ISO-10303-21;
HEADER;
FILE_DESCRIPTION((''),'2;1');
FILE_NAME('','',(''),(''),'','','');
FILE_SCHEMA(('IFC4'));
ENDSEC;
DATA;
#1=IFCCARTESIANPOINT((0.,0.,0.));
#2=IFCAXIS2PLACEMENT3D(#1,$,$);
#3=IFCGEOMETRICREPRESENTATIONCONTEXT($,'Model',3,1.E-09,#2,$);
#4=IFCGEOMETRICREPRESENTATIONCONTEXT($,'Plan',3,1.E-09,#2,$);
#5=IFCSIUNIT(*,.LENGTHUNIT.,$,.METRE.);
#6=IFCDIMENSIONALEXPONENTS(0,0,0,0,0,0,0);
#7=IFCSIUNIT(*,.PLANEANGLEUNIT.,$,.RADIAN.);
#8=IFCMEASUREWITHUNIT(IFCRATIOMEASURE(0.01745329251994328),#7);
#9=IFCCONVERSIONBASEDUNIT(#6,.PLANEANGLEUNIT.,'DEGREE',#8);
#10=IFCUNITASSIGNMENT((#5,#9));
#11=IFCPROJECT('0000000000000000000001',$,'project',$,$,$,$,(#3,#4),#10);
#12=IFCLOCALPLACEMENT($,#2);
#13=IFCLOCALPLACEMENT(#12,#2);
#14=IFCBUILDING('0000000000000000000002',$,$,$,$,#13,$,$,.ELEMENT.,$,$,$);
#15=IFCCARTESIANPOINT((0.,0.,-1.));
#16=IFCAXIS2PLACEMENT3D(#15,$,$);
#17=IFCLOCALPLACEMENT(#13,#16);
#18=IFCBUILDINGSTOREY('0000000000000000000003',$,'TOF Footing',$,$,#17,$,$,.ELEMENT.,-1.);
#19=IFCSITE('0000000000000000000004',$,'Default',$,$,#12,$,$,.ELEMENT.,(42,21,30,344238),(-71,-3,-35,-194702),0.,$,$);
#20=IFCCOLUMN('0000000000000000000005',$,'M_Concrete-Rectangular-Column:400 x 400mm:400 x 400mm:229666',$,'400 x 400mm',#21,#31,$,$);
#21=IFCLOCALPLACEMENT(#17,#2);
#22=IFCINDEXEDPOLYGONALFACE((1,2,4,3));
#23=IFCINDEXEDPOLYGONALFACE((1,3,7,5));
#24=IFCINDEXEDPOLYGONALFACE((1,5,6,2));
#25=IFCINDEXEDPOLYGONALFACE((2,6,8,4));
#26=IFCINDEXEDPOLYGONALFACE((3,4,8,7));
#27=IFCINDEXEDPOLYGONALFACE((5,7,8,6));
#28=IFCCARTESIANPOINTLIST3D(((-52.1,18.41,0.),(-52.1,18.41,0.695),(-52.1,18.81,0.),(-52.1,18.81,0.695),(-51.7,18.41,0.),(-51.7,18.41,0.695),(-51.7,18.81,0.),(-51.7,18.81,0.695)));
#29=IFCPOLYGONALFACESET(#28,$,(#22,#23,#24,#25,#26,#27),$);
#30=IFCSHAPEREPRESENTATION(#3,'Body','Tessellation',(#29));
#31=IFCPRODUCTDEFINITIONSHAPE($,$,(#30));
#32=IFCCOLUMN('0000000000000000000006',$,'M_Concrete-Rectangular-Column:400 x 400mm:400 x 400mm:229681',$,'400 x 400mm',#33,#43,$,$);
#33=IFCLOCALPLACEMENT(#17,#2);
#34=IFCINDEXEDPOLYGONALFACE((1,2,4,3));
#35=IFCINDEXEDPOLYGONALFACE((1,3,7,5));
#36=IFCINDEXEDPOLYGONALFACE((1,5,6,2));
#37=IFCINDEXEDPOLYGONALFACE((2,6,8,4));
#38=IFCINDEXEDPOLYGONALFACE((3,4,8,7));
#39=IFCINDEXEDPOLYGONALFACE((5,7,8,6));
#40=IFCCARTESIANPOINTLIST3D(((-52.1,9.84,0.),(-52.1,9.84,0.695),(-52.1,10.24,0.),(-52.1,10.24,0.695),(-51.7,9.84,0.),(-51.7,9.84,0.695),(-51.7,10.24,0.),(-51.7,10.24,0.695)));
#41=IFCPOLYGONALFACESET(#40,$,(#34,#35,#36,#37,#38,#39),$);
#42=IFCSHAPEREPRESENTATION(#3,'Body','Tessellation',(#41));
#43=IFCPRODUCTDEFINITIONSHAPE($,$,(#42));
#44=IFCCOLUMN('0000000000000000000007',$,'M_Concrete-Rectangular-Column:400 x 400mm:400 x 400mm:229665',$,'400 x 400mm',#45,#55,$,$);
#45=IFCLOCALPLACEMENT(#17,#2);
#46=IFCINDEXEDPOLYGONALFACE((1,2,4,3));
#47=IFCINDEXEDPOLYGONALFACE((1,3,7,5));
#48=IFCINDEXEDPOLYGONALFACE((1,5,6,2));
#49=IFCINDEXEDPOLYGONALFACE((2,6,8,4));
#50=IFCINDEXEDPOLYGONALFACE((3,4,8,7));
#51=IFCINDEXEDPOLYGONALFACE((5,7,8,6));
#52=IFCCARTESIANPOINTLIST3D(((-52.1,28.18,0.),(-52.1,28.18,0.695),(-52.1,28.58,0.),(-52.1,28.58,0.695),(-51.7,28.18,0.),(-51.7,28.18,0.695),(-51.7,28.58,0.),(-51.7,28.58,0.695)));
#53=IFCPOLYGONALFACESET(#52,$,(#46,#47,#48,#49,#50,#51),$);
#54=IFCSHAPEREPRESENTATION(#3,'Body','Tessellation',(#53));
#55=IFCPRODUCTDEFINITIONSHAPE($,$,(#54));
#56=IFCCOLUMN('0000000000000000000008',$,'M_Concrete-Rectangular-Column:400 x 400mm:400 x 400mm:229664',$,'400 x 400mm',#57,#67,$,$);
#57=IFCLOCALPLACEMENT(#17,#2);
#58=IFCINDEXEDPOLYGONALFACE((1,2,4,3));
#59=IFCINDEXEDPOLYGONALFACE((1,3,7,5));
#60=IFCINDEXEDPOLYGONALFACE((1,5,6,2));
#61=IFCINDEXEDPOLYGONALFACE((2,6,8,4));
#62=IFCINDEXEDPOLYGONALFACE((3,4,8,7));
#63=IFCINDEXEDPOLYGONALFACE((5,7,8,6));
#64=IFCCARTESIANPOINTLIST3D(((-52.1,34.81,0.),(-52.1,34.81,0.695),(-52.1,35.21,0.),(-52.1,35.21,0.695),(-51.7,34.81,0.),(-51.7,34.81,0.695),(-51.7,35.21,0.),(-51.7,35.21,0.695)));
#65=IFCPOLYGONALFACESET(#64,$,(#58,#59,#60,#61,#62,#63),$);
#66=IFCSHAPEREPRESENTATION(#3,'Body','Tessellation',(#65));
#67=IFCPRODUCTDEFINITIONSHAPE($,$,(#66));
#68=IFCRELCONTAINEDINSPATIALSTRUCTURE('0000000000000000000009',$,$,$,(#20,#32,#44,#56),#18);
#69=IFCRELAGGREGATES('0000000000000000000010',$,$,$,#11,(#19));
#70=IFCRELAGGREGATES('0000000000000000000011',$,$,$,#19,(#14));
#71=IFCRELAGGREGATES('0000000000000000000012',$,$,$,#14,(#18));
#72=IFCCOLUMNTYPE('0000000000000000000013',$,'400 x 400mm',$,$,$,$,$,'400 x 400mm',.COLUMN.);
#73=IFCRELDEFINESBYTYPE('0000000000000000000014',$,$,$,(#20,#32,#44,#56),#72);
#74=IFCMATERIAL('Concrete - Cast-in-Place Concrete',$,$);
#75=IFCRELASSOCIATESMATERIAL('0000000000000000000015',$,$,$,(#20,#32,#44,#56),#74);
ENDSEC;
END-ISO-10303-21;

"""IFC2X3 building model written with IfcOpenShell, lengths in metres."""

from ifc_helpers import new_model, entity, si_unit, converted_unit, frame, frame_2d, origin, place, context, project, spatial, rectangle, extrude, source, transform, mapped, material, type_object, type_shapes, element, save


model = new_model("IFC2X3")

# Units and contexts
model_context = context("Model", 3, precision=1e-09, world=origin())
plan_context = context("Plan", 3, precision=1e-09, world=origin())
ifc_project = project(units=[si_unit("LENGTHUNIT", "METRE"), converted_unit("PLANEANGLEUNIT", "DEGREE", entity("IfcRatioMeasure", 0.01745329251994328), si_unit("PLANEANGLEUNIT", "RADIAN"), dimensions=[0, 0, 0, 0, 0, 0, 0])], contexts=[model_context, plan_context])

# Site, building, storey
site_placement = place(None, origin())
site = spatial("IfcSite", under=ifc_project, at=site_placement, Name="Default", CompositionType="ELEMENT", RefLatitude=(42, 21, 30, 344238), RefLongitude=(-71, -3, -35, -194702), RefElevation=0.0)
building_placement = place(site_placement, origin())
building = spatial("IfcBuilding", under=site, at=building_placement, CompositionType="ELEMENT")
storey_placement = place(building_placement, frame((0.0, 0.0, -1.0)))
storey = spatial("IfcBuildingStorey", under=building, at=storey_placement, Name="TOF Footing", CompositionType="ELEMENT", Elevation=-1.0)

# Columns
ifc_material_1 = material(Name="Concrete - Cast-in-Place Concrete")
column_type_1 = type_object("IfcColumnType", Name="400 x 400mm", ElementType="400 x 400mm", PredefinedType="COLUMN")
shared_shape_1 = source(origin(), model_context, "Body", "SweptSolid", [
    extrude(rectangle(XDim=0.4, YDim=0.4, at=frame_2d((0.0, 0.0), x_axis=(0.0, -1.0))), origin(), (0.0, 0.0, 1.0), 0.695),
])
type_shapes(column_type_1, [shared_shape_1])
for number, where, z_axis, x_axis, name in (
    (1, (-51.9, 18.61, 0.0), (0.0, 0.0, 1.0), (0.0, 1.0, 0.0), "M_Concrete-Rectangular-Column:400 x 400mm:400 x 400mm:229666"),
    (2, (-51.9, 10.04, 0.0), (0.0, 0.0, 1.0), (0.0, 1.0, 0.0), "M_Concrete-Rectangular-Column:400 x 400mm:400 x 400mm:229681"),
    (3, (-51.9, 28.38, 0.0), (0.0, 0.0, 1.0), (0.0, -1.0, 0.0), "M_Concrete-Rectangular-Column:400 x 400mm:400 x 400mm:229665"),
    (4, (-51.9, 35.01, 0.0), (0.0, 0.0, 1.0), (0.0, -1.0, 0.0), "M_Concrete-Rectangular-Column:400 x 400mm:400 x 400mm:229664"),
):
    element("IfcColumn", number, at=place(storey_placement, frame(where, z_axis=z_axis, x_axis=x_axis)), inside=storey, type_object=column_type_1, material=ifc_material_1, Name=name, ObjectType="400 x 400mm", context=model_context, shape_type="MappedRepresentation", body=[
        mapped(shared_shape_1, transform((0.0, 0.0, 0.0), scale=1.0)),
    ])

save(model, "model.ifc")
